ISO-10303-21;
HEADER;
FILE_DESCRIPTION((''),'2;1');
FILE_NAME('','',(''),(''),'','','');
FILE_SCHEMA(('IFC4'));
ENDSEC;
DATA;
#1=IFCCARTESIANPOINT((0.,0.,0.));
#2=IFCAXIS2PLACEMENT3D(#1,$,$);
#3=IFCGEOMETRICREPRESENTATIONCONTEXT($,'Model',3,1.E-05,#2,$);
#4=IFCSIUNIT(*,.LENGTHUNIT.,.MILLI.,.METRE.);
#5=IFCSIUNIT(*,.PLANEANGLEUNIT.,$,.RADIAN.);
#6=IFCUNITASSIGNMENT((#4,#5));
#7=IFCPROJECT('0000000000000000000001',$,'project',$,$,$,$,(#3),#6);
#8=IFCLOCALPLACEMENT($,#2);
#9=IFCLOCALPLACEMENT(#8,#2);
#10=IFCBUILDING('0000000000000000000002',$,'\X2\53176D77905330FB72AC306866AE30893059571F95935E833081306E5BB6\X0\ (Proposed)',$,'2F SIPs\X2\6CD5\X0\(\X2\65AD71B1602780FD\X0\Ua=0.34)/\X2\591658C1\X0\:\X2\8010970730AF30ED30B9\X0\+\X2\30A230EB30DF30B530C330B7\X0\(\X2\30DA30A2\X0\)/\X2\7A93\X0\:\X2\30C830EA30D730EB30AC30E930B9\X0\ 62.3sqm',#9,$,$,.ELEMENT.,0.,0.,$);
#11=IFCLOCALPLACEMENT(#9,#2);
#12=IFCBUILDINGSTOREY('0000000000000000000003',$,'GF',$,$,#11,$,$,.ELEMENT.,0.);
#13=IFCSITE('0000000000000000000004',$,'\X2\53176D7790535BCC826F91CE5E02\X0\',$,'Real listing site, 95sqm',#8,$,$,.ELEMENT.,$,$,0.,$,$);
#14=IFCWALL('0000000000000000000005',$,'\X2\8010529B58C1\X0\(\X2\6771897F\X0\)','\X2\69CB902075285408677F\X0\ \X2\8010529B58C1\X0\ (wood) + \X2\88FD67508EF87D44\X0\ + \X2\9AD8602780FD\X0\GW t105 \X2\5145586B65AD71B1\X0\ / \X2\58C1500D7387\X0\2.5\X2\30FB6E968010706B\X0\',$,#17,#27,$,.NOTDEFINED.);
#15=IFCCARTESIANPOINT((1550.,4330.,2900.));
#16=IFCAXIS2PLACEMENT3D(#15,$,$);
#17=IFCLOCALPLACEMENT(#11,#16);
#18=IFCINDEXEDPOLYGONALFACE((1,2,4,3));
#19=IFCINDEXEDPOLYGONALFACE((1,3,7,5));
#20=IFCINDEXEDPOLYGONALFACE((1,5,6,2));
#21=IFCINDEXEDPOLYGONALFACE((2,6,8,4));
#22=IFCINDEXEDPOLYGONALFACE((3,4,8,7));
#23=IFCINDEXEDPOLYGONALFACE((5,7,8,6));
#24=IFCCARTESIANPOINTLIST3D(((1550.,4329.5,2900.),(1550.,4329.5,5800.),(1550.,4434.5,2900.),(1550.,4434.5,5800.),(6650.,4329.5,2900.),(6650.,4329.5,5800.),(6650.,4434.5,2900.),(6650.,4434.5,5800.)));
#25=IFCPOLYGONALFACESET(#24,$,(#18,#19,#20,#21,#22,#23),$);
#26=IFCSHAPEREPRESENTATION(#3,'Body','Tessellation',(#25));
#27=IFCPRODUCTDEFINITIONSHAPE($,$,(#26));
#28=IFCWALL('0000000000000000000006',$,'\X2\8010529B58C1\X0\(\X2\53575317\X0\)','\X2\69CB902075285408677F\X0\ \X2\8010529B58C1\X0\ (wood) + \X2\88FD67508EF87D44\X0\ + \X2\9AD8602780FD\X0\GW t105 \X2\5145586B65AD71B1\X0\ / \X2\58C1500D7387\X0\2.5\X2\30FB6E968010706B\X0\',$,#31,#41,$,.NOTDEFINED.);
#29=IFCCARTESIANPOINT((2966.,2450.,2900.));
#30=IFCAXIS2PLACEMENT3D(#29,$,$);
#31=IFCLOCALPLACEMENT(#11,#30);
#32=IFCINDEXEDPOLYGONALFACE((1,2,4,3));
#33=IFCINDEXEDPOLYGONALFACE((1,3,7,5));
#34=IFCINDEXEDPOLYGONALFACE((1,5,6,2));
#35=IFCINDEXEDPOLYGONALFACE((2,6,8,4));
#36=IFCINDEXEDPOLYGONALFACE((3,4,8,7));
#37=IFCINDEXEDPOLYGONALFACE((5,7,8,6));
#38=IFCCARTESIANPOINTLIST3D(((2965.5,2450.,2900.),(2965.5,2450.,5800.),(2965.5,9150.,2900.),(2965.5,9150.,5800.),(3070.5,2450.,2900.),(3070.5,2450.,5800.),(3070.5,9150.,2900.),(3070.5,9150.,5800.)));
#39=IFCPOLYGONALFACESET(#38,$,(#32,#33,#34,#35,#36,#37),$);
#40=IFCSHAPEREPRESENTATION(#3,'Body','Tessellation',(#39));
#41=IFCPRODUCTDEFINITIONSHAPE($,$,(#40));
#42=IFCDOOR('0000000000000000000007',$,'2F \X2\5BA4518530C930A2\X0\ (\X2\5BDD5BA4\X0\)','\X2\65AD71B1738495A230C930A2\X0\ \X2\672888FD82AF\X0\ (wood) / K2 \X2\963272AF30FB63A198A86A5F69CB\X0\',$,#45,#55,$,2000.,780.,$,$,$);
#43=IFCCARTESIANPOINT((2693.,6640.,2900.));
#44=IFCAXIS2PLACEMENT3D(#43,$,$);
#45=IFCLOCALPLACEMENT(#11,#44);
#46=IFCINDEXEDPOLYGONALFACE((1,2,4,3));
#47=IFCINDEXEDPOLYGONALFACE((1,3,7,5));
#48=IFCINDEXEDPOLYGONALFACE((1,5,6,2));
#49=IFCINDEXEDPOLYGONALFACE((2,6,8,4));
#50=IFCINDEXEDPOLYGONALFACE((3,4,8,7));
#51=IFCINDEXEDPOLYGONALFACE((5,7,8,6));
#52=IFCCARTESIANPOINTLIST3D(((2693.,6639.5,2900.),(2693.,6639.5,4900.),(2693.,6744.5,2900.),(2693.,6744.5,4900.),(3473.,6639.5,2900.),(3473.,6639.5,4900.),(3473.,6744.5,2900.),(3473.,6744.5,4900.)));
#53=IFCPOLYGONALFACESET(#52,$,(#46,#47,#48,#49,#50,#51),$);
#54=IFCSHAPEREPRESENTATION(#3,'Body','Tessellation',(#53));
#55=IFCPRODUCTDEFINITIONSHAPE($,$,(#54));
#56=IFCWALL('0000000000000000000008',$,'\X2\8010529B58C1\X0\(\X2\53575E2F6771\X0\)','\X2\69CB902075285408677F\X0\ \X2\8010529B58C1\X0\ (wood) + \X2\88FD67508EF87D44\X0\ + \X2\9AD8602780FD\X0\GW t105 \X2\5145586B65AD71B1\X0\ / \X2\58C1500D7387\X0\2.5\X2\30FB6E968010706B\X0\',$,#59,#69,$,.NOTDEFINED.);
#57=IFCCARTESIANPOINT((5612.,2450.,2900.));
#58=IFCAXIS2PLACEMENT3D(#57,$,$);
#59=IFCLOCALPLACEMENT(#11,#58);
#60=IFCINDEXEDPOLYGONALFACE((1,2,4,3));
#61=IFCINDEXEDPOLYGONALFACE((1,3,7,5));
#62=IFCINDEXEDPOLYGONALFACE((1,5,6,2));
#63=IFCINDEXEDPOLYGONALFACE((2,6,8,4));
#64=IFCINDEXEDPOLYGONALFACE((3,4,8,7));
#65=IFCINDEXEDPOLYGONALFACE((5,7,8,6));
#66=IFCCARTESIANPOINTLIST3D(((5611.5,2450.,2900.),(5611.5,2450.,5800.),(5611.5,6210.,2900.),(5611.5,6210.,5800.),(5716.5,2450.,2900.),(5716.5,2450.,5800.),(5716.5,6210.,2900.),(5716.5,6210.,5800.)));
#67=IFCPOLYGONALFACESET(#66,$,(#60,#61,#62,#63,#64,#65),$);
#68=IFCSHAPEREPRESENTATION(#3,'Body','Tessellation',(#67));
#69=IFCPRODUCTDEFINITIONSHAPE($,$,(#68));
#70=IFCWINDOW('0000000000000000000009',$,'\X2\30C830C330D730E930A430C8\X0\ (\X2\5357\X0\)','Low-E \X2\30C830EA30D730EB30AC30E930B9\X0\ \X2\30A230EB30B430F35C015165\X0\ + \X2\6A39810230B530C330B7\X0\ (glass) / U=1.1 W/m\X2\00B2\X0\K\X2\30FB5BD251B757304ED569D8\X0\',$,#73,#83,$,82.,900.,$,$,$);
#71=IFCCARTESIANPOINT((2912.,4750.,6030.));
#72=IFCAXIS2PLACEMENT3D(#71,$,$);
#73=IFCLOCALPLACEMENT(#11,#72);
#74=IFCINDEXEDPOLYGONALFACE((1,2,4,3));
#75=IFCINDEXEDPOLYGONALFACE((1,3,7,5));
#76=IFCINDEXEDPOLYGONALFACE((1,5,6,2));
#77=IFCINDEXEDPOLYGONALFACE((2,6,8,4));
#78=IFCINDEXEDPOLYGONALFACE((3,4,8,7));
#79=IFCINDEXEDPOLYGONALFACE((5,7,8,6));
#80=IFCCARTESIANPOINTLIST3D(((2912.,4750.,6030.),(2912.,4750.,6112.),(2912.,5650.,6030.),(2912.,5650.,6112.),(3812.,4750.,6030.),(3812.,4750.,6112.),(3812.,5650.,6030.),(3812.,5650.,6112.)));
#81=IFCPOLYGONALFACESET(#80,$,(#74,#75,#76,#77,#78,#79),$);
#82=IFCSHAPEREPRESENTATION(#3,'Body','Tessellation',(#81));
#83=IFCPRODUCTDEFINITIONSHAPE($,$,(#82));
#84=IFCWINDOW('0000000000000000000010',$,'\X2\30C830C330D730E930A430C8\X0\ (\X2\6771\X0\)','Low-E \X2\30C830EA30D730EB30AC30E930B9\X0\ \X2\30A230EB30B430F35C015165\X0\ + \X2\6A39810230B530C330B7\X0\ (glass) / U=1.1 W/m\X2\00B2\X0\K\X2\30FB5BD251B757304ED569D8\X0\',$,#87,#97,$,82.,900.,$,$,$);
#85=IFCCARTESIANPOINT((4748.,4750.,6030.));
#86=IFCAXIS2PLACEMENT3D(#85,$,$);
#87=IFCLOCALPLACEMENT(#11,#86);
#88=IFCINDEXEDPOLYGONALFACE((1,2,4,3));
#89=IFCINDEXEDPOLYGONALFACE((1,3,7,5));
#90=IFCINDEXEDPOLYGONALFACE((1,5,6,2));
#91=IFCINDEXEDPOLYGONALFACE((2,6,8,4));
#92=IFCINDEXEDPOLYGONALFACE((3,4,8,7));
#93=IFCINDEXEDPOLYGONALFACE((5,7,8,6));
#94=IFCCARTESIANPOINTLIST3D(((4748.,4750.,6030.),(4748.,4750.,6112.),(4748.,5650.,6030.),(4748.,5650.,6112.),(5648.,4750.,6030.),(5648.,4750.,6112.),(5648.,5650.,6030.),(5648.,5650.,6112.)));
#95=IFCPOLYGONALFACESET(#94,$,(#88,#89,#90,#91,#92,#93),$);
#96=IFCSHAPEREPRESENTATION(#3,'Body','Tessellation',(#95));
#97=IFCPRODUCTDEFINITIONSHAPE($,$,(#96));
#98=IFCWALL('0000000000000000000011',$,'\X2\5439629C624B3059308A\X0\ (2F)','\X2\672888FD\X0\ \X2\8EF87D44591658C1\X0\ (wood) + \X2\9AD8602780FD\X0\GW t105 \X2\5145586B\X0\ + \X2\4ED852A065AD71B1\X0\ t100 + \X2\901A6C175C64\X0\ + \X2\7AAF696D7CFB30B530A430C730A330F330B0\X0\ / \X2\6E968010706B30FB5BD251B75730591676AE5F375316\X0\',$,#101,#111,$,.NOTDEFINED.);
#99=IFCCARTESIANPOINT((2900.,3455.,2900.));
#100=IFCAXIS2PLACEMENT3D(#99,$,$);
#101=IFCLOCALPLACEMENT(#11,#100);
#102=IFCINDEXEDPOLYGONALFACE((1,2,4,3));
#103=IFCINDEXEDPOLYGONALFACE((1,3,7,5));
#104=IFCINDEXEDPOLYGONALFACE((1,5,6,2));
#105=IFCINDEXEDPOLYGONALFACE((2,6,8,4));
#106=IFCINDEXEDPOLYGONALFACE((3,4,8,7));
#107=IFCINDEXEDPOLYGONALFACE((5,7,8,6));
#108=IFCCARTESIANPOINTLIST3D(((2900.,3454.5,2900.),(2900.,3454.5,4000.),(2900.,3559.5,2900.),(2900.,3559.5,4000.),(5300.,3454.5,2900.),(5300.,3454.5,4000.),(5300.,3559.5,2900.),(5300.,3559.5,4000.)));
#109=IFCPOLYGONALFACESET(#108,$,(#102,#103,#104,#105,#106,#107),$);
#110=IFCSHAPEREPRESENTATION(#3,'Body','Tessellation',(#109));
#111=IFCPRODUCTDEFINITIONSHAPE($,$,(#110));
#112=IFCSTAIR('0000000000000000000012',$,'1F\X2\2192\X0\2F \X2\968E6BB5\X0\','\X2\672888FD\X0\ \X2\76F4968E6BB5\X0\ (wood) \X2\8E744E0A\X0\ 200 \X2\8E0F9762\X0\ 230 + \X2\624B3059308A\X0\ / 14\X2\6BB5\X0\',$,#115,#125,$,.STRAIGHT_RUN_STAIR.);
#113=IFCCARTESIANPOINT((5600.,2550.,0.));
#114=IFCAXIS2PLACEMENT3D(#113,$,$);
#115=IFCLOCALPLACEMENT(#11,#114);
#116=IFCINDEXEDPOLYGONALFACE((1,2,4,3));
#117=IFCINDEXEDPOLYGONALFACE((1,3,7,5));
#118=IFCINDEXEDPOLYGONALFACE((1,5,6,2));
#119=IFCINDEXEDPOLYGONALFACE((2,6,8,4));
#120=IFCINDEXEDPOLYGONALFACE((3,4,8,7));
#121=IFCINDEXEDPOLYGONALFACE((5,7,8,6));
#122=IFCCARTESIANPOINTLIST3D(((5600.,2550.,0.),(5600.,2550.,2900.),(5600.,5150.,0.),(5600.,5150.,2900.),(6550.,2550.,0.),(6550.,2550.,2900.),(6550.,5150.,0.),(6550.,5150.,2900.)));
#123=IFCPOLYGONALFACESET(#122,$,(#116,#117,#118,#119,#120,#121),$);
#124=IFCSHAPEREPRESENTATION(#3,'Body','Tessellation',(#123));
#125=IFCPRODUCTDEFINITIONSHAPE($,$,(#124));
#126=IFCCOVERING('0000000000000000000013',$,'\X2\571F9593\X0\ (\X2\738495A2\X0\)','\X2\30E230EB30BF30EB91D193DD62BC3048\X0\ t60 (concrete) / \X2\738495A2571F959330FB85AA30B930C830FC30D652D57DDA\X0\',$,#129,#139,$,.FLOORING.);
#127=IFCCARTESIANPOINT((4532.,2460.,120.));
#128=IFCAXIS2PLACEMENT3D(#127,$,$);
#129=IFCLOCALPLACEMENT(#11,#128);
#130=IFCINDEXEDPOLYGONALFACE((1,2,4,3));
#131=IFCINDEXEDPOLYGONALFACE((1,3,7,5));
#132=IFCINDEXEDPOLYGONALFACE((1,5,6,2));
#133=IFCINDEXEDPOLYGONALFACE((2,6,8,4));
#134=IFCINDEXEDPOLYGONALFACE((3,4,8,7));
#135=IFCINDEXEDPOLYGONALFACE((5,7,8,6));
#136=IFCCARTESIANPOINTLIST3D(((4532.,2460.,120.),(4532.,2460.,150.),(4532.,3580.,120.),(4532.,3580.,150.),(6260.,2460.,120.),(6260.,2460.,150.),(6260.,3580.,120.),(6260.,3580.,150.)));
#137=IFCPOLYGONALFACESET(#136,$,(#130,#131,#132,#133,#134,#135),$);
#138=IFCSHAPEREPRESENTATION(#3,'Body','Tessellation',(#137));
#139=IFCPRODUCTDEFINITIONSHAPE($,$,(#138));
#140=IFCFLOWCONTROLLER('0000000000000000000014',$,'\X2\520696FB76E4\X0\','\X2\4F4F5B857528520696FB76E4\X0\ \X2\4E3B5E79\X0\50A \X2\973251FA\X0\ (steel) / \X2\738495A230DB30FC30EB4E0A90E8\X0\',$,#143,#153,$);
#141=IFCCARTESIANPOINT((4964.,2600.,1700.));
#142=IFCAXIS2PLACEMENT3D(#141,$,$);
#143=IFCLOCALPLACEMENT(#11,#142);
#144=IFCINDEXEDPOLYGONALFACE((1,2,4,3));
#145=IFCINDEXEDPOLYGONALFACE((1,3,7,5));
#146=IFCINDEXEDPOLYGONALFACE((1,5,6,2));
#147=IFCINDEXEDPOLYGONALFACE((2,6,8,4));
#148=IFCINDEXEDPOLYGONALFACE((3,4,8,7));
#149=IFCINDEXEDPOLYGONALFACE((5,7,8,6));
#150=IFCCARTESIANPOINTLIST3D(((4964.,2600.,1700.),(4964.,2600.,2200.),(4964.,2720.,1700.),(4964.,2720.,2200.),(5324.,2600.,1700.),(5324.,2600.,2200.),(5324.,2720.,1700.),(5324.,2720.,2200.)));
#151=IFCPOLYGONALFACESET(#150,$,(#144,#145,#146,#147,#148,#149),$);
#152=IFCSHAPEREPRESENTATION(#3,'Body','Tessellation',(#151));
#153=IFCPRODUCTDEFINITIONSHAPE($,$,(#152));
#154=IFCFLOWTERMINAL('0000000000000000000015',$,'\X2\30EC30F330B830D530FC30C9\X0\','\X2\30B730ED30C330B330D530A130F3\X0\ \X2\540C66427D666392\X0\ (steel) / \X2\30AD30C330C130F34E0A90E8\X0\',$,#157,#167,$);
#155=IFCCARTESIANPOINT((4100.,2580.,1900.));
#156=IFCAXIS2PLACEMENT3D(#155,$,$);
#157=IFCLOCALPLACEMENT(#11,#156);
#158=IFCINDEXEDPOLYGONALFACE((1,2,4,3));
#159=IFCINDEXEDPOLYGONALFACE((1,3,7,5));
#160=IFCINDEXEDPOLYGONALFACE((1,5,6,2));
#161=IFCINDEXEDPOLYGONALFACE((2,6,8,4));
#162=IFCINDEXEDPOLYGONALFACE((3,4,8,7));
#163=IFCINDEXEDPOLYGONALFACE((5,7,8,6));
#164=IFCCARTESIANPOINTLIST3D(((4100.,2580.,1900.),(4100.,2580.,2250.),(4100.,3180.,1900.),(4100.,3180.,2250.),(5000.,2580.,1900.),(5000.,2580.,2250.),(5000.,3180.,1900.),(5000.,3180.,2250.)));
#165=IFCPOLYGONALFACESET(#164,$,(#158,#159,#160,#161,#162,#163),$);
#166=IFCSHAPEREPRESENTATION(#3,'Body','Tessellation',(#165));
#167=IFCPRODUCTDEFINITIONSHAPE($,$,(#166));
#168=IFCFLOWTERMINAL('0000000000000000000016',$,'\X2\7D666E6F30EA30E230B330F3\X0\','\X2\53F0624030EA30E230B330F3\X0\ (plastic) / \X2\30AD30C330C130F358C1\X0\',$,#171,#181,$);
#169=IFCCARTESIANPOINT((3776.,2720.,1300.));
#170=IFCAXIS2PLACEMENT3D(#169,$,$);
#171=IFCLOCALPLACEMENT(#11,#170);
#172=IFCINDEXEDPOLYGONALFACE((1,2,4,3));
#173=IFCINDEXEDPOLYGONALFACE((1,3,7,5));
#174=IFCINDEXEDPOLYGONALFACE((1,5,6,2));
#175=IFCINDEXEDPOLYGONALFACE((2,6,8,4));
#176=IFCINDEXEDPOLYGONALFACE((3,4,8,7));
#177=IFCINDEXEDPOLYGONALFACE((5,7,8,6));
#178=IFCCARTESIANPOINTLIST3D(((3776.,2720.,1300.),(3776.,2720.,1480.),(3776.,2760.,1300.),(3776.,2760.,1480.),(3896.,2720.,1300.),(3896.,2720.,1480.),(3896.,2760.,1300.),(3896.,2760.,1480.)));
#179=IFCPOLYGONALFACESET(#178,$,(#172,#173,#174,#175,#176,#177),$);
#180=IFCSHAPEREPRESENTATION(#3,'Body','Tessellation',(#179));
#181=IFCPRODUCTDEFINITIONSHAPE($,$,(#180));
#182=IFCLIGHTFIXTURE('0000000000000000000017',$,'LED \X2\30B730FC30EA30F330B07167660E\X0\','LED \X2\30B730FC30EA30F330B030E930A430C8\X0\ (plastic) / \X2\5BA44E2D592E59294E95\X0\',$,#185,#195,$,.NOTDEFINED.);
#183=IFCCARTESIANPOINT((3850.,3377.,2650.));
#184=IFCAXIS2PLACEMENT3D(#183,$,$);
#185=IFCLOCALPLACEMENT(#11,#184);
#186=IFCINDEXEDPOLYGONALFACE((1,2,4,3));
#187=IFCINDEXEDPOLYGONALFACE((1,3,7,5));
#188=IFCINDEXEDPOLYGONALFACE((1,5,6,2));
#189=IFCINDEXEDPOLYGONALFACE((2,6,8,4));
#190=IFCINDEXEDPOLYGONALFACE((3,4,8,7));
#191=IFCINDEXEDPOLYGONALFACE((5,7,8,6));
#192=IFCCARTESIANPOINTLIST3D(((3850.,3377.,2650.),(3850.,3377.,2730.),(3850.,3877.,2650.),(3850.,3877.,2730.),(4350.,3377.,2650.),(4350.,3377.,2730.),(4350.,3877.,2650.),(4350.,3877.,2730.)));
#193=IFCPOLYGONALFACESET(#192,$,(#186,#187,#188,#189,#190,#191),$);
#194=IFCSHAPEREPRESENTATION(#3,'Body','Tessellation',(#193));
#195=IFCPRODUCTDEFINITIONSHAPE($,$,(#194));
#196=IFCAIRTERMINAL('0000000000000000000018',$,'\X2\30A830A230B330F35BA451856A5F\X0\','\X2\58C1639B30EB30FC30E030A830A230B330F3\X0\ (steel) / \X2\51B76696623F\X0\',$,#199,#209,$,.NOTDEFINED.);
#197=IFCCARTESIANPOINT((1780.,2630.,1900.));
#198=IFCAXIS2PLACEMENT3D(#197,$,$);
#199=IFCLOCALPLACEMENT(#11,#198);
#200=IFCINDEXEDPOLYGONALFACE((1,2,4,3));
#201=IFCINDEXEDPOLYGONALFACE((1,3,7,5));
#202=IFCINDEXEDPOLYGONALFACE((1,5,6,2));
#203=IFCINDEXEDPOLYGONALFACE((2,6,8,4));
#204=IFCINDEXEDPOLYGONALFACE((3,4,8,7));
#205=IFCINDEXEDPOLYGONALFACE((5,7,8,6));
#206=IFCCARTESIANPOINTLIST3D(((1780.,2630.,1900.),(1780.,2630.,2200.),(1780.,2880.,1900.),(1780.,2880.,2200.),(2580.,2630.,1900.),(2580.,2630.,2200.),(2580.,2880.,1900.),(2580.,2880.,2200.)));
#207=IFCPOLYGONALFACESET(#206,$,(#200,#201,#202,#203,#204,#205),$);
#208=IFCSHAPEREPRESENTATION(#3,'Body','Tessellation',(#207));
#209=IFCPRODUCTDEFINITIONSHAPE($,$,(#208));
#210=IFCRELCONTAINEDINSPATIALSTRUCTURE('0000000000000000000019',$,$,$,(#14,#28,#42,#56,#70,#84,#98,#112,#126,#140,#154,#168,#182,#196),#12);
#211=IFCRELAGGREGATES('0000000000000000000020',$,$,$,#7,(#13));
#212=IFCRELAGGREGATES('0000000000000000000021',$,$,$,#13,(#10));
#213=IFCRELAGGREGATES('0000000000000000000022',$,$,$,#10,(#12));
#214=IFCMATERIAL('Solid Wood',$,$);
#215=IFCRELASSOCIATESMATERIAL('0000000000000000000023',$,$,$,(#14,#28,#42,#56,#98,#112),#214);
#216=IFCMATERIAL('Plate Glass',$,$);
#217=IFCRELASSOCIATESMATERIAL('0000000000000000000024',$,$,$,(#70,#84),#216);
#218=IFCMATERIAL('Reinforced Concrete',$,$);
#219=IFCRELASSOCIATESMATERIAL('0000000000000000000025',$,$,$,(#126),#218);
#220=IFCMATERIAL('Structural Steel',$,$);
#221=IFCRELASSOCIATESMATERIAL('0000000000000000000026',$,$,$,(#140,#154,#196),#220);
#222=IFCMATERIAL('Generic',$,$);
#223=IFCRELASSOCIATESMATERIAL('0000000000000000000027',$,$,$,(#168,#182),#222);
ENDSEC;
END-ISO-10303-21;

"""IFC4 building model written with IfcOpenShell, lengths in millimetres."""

from ifc_helpers import new_model, si_unit, frame, frame_2d, origin, place, context, project, spatial, rectangle, extrude, material, element, fill, save


model = new_model("IFC4")

# Units and contexts
model_context = context("Model", 3, precision=1e-05, world=origin())
ifc_project = project(units=[si_unit("LENGTHUNIT", "METRE", prefix="MILLI"), si_unit("PLANEANGLEUNIT", "RADIAN")], contexts=[model_context])

# Site, building, storey
site_placement = place(None, origin())
site = spatial("IfcSite", under=ifc_project, at=site_placement, Name="北海道富良野市", ObjectType="Real listing site, 95sqm", CompositionType="ELEMENT", RefElevation=0.0)
building_placement = place(site_placement, origin())
building = spatial("IfcBuilding", under=site, at=building_placement, Name="北海道・犬と暮らす土間広めの家 (Proposed)", ObjectType="2F SIPs法(断熱性能Ua=0.34)/外壁:耐震クロス+アルミサッシ(ペア)/窓:トリプルガラス 62.3sqm", CompositionType="ELEMENT", ElevationOfRefHeight=0.0, ElevationOfTerrain=0.0)
storey_placement = place(building_placement, origin())
storey = spatial("IfcBuildingStorey", under=building, at=storey_placement, Name="GF", CompositionType="ELEMENT", Elevation=0.0)

# Shared definitions
ifc_material_1 = material(Name="Solid Wood")

# Wall
wall_1_placement = place(storey_placement, frame((1550.0, 4330.0, 2900.0)))
element("IfcWall", 1, at=wall_1_placement, inside=storey, material=ifc_material_1, Name="耐力壁(東西)", Description="構造用合板 耐力壁 (wood) + 製材軸組 + 高性能GW t105 充填断熱 / 壁倍率2.5・準耐火", PredefinedType="NOTDEFINED", context=model_context, shape_type="SweptSolid", body=[
    extrude(rectangle(XDim=5100.0, YDim=105.0, at=frame_2d((2550.0, 52.0))), frame((1550.0, 4330.0, 2900.0)), (0.0, 0.0, 1.0), 2900.0),
])

# Wall, opening, door
wall_2_placement = place(storey_placement, frame((2966.0, 2450.0, 2900.0)))
wall_2 = element("IfcWall", 2, at=wall_2_placement, inside=storey, material=ifc_material_1, Name="耐力壁(南北)", Description="構造用合板 耐力壁 (wood) + 製材軸組 + 高性能GW t105 充填断熱 / 壁倍率2.5・準耐火", PredefinedType="NOTDEFINED", context=model_context, shape_type="SweptSolid", body=[
    extrude(rectangle(XDim=105.0, YDim=6700.0, at=frame_2d((52.0, 3350.0))), frame((2966.0, 2450.0, 2900.0)), (0.0, 0.0, 1.0), 2900.0),
])
opening_placement = place(storey_placement, frame((2693.0, 6640.0, 2900.0)))
opening = element("IfcOpeningElement", 3, at=opening_placement, cuts=wall_2, PredefinedType="NOTDEFINED", context=model_context, shape_type="SweptSolid", body=[
    extrude(rectangle(XDim=780.0, YDim=105.0, at=frame_2d((390.0, 52.0))), frame((2693.0, 6640.0, 2900.0)), (0.0, 0.0, 1.0), 2000.0),
])
door_placement = place(storey_placement, frame((2693.0, 6640.0, 2900.0)))
door = element("IfcDoor", 4, at=door_placement, inside=storey, material=ifc_material_1, Name="2F 室内ドア (寝室)", Description="断熱玄関ドア 木製芯 (wood) / K2 防犯・採風機構", OverallHeight=2000.0, OverallWidth=780.0, context=model_context, shape_type="SweptSolid", body=[
    extrude(rectangle(XDim=780.0, YDim=105.0, at=frame_2d((390.0, 52.0))), frame((2693.0, 6640.0, 2900.0)), (0.0, 0.0, 1.0), 2000.0),
])
fill(opening, door)

# Wall
wall_3_placement = place(storey_placement, frame((5612.0, 2450.0, 2900.0)))
element("IfcWall", 5, at=wall_3_placement, inside=storey, material=ifc_material_1, Name="耐力壁(南帯東)", Description="構造用合板 耐力壁 (wood) + 製材軸組 + 高性能GW t105 充填断熱 / 壁倍率2.5・準耐火", PredefinedType="NOTDEFINED", context=model_context, shape_type="SweptSolid", body=[
    extrude(rectangle(XDim=105.0, YDim=3760.0, at=frame_2d((52.0, 1880.0))), frame((5612.0, 2450.0, 2900.0)), (0.0, 0.0, 1.0), 2900.0),
])

# Windows
ifc_material_2 = material(Name="Plate Glass")
window_1_placement = place(storey_placement, frame((2912.0, 4750.0, 6030.0)))
element("IfcWindow", 6, at=window_1_placement, inside=storey, material=ifc_material_2, Name="トップライト (南)", Description="Low-E トリプルガラス アルゴン封入 + 樹脂サッシ (glass) / U=1.1 W/m²K・寒冷地仕様", OverallHeight=82.0, OverallWidth=900.0, context=model_context, shape_type="SweptSolid", body=[
    extrude(rectangle(XDim=900.0, YDim=900.0, at=frame_2d((450.0, 450.0))), frame((2912.0, 4750.0, 6030.0)), (0.0, 0.0, 1.0), 82.0),
])
window_2_placement = place(storey_placement, frame((4748.0, 4750.0, 6030.0)))
element("IfcWindow", 7, at=window_2_placement, inside=storey, material=ifc_material_2, Name="トップライト (東)", Description="Low-E トリプルガラス アルゴン封入 + 樹脂サッシ (glass) / U=1.1 W/m²K・寒冷地仕様", OverallHeight=82.0, OverallWidth=900.0, context=model_context, shape_type="SweptSolid", body=[
    extrude(rectangle(XDim=900.0, YDim=900.0, at=frame_2d((450.0, 450.0))), frame((4748.0, 4750.0, 6030.0)), (0.0, 0.0, 1.0), 82.0),
])

# Wall
wall_4_placement = place(storey_placement, frame((2900.0, 3455.0, 2900.0)))
element("IfcWall", 8, at=wall_4_placement, inside=storey, material=ifc_material_1, Name="吹抜手すり (2F)", Description="木製 軸組外壁 (wood) + 高性能GW t105 充填 + 付加断熱 t100 + 通気層 + 窯業系サイディング / 準耐火・寒冷地外皮強化", PredefinedType="NOTDEFINED", context=model_context, shape_type="SweptSolid", body=[
    extrude(rectangle(XDim=2400.0, YDim=105.0, at=frame_2d((1200.0, 52.0))), frame((2900.0, 3455.0, 2900.0)), (0.0, 0.0, 1.0), 1100.0),
])

# Stair
stair_placement = place(storey_placement, frame((5600.0, 2550.0, 0.0)))
element("IfcStair", 9, at=stair_placement, inside=storey, material=ifc_material_1, Name="1F→2F 階段", Description="木製 直階段 (wood) 蹴上 200 踏面 230 + 手すり / 14段", PredefinedType="STRAIGHT_RUN_STAIR", context=model_context, shape_type="SweptSolid", body=[
    extrude(rectangle(XDim=950.0, YDim=2600.0, at=frame_2d((475.0, 1300.0))), frame((5600.0, 2550.0, 0.0)), (0.0, 0.0, 1.0), 2900.0),
])

# Covering
ifc_material_3 = material(Name="Reinforced Concrete")
covering_placement = place(storey_placement, frame((4532.0, 2460.0, 120.0)))
element("IfcCovering", 10, at=covering_placement, inside=storey, material=ifc_material_3, Name="土間 (玄関)", Description="モルタル金鏝押え t60 (concrete) / 玄関土間・薪ストーブ動線", PredefinedType="FLOORING", context=model_context, shape_type="SweptSolid", body=[
    extrude(rectangle(XDim=1728.0, YDim=1120.0, at=frame_2d((864.0, 560.0))), frame((4532.0, 2460.0, 120.0)), (0.0, 0.0, 1.0), 30.0),
])

# Shared definitions
ifc_material_4 = material(Name="Structural Steel")

# Flow controller
flow_controller_placement = place(storey_placement, frame((4964.0, 2600.0, 1700.0)))
element("IfcFlowController", 11, at=flow_controller_placement, inside=storey, material=ifc_material_4, Name="分電盤", Description="住宅用分電盤 主幹50A 露出 (steel) / 玄関ホール上部", context=model_context, shape_type="SweptSolid", body=[
    extrude(rectangle(XDim=360.0, YDim=120.0, at=frame_2d((180.0, 60.0))), frame((4964.0, 2600.0, 1700.0)), (0.0, 0.0, 1.0), 500.0),
])

# Flow terminals
flow_terminal_1_placement = place(storey_placement, frame((4100.0, 2580.0, 1900.0)))
element("IfcFlowTerminal", 12, at=flow_terminal_1_placement, inside=storey, material=ifc_material_4, Name="レンジフード", Description="シロッコファン 同時給排 (steel) / キッチン上部", context=model_context, shape_type="SweptSolid", body=[
    extrude(rectangle(XDim=900.0, YDim=600.0, at=frame_2d((450.0, 300.0))), frame((4100.0, 2580.0, 1900.0)), (0.0, 0.0, 1.0), 350.0),
])
ifc_material_5 = material(Name="Generic")
flow_terminal_2_placement = place(storey_placement, frame((3776.0, 2720.0, 1300.0)))
element("IfcFlowTerminal", 13, at=flow_terminal_2_placement, inside=storey, material=ifc_material_5, Name="給湯リモコン", Description="台所リモコン (plastic) / キッチン壁", context=model_context, shape_type="SweptSolid", body=[
    extrude(rectangle(XDim=120.0, YDim=40.0, at=frame_2d((60.0, 20.0))), frame((3776.0, 2720.0, 1300.0)), (0.0, 0.0, 1.0), 180.0),
])

# Light fixture
light_fixture_1_placement = place(storey_placement, frame((3850.0, 3377.0, 2650.0)))
element("IfcLightFixture", 14, at=light_fixture_1_placement, inside=storey, material=ifc_material_5, Name="LED シーリング照明", Description="LED シーリングライト (plastic) / 室中央天井", PredefinedType="NOTDEFINED", context=model_context, shape_type="SweptSolid", body=[
    extrude(rectangle(XDim=500.0, YDim=500.0, at=frame_2d((250.0, 250.0))), frame((3850.0, 3377.0, 2650.0)), (0.0, 0.0, 1.0), 80.0),
])

# Air terminal
air_terminal_1_placement = place(storey_placement, frame((1780.0, 2630.0, 1900.0)))
element("IfcAirTerminal", 15, at=air_terminal_1_placement, inside=storey, material=ifc_material_4, Name="エアコン室内機", Description="壁掛ルームエアコン (steel) / 冷暖房", PredefinedType="NOTDEFINED", context=model_context, shape_type="SweptSolid", body=[
    extrude(rectangle(XDim=800.0, YDim=250.0, at=frame_2d((400.0, 125.0))), frame((1780.0, 2630.0, 1900.0)), (0.0, 0.0, 1.0), 300.0),
])

save(model, "model.ifc")
